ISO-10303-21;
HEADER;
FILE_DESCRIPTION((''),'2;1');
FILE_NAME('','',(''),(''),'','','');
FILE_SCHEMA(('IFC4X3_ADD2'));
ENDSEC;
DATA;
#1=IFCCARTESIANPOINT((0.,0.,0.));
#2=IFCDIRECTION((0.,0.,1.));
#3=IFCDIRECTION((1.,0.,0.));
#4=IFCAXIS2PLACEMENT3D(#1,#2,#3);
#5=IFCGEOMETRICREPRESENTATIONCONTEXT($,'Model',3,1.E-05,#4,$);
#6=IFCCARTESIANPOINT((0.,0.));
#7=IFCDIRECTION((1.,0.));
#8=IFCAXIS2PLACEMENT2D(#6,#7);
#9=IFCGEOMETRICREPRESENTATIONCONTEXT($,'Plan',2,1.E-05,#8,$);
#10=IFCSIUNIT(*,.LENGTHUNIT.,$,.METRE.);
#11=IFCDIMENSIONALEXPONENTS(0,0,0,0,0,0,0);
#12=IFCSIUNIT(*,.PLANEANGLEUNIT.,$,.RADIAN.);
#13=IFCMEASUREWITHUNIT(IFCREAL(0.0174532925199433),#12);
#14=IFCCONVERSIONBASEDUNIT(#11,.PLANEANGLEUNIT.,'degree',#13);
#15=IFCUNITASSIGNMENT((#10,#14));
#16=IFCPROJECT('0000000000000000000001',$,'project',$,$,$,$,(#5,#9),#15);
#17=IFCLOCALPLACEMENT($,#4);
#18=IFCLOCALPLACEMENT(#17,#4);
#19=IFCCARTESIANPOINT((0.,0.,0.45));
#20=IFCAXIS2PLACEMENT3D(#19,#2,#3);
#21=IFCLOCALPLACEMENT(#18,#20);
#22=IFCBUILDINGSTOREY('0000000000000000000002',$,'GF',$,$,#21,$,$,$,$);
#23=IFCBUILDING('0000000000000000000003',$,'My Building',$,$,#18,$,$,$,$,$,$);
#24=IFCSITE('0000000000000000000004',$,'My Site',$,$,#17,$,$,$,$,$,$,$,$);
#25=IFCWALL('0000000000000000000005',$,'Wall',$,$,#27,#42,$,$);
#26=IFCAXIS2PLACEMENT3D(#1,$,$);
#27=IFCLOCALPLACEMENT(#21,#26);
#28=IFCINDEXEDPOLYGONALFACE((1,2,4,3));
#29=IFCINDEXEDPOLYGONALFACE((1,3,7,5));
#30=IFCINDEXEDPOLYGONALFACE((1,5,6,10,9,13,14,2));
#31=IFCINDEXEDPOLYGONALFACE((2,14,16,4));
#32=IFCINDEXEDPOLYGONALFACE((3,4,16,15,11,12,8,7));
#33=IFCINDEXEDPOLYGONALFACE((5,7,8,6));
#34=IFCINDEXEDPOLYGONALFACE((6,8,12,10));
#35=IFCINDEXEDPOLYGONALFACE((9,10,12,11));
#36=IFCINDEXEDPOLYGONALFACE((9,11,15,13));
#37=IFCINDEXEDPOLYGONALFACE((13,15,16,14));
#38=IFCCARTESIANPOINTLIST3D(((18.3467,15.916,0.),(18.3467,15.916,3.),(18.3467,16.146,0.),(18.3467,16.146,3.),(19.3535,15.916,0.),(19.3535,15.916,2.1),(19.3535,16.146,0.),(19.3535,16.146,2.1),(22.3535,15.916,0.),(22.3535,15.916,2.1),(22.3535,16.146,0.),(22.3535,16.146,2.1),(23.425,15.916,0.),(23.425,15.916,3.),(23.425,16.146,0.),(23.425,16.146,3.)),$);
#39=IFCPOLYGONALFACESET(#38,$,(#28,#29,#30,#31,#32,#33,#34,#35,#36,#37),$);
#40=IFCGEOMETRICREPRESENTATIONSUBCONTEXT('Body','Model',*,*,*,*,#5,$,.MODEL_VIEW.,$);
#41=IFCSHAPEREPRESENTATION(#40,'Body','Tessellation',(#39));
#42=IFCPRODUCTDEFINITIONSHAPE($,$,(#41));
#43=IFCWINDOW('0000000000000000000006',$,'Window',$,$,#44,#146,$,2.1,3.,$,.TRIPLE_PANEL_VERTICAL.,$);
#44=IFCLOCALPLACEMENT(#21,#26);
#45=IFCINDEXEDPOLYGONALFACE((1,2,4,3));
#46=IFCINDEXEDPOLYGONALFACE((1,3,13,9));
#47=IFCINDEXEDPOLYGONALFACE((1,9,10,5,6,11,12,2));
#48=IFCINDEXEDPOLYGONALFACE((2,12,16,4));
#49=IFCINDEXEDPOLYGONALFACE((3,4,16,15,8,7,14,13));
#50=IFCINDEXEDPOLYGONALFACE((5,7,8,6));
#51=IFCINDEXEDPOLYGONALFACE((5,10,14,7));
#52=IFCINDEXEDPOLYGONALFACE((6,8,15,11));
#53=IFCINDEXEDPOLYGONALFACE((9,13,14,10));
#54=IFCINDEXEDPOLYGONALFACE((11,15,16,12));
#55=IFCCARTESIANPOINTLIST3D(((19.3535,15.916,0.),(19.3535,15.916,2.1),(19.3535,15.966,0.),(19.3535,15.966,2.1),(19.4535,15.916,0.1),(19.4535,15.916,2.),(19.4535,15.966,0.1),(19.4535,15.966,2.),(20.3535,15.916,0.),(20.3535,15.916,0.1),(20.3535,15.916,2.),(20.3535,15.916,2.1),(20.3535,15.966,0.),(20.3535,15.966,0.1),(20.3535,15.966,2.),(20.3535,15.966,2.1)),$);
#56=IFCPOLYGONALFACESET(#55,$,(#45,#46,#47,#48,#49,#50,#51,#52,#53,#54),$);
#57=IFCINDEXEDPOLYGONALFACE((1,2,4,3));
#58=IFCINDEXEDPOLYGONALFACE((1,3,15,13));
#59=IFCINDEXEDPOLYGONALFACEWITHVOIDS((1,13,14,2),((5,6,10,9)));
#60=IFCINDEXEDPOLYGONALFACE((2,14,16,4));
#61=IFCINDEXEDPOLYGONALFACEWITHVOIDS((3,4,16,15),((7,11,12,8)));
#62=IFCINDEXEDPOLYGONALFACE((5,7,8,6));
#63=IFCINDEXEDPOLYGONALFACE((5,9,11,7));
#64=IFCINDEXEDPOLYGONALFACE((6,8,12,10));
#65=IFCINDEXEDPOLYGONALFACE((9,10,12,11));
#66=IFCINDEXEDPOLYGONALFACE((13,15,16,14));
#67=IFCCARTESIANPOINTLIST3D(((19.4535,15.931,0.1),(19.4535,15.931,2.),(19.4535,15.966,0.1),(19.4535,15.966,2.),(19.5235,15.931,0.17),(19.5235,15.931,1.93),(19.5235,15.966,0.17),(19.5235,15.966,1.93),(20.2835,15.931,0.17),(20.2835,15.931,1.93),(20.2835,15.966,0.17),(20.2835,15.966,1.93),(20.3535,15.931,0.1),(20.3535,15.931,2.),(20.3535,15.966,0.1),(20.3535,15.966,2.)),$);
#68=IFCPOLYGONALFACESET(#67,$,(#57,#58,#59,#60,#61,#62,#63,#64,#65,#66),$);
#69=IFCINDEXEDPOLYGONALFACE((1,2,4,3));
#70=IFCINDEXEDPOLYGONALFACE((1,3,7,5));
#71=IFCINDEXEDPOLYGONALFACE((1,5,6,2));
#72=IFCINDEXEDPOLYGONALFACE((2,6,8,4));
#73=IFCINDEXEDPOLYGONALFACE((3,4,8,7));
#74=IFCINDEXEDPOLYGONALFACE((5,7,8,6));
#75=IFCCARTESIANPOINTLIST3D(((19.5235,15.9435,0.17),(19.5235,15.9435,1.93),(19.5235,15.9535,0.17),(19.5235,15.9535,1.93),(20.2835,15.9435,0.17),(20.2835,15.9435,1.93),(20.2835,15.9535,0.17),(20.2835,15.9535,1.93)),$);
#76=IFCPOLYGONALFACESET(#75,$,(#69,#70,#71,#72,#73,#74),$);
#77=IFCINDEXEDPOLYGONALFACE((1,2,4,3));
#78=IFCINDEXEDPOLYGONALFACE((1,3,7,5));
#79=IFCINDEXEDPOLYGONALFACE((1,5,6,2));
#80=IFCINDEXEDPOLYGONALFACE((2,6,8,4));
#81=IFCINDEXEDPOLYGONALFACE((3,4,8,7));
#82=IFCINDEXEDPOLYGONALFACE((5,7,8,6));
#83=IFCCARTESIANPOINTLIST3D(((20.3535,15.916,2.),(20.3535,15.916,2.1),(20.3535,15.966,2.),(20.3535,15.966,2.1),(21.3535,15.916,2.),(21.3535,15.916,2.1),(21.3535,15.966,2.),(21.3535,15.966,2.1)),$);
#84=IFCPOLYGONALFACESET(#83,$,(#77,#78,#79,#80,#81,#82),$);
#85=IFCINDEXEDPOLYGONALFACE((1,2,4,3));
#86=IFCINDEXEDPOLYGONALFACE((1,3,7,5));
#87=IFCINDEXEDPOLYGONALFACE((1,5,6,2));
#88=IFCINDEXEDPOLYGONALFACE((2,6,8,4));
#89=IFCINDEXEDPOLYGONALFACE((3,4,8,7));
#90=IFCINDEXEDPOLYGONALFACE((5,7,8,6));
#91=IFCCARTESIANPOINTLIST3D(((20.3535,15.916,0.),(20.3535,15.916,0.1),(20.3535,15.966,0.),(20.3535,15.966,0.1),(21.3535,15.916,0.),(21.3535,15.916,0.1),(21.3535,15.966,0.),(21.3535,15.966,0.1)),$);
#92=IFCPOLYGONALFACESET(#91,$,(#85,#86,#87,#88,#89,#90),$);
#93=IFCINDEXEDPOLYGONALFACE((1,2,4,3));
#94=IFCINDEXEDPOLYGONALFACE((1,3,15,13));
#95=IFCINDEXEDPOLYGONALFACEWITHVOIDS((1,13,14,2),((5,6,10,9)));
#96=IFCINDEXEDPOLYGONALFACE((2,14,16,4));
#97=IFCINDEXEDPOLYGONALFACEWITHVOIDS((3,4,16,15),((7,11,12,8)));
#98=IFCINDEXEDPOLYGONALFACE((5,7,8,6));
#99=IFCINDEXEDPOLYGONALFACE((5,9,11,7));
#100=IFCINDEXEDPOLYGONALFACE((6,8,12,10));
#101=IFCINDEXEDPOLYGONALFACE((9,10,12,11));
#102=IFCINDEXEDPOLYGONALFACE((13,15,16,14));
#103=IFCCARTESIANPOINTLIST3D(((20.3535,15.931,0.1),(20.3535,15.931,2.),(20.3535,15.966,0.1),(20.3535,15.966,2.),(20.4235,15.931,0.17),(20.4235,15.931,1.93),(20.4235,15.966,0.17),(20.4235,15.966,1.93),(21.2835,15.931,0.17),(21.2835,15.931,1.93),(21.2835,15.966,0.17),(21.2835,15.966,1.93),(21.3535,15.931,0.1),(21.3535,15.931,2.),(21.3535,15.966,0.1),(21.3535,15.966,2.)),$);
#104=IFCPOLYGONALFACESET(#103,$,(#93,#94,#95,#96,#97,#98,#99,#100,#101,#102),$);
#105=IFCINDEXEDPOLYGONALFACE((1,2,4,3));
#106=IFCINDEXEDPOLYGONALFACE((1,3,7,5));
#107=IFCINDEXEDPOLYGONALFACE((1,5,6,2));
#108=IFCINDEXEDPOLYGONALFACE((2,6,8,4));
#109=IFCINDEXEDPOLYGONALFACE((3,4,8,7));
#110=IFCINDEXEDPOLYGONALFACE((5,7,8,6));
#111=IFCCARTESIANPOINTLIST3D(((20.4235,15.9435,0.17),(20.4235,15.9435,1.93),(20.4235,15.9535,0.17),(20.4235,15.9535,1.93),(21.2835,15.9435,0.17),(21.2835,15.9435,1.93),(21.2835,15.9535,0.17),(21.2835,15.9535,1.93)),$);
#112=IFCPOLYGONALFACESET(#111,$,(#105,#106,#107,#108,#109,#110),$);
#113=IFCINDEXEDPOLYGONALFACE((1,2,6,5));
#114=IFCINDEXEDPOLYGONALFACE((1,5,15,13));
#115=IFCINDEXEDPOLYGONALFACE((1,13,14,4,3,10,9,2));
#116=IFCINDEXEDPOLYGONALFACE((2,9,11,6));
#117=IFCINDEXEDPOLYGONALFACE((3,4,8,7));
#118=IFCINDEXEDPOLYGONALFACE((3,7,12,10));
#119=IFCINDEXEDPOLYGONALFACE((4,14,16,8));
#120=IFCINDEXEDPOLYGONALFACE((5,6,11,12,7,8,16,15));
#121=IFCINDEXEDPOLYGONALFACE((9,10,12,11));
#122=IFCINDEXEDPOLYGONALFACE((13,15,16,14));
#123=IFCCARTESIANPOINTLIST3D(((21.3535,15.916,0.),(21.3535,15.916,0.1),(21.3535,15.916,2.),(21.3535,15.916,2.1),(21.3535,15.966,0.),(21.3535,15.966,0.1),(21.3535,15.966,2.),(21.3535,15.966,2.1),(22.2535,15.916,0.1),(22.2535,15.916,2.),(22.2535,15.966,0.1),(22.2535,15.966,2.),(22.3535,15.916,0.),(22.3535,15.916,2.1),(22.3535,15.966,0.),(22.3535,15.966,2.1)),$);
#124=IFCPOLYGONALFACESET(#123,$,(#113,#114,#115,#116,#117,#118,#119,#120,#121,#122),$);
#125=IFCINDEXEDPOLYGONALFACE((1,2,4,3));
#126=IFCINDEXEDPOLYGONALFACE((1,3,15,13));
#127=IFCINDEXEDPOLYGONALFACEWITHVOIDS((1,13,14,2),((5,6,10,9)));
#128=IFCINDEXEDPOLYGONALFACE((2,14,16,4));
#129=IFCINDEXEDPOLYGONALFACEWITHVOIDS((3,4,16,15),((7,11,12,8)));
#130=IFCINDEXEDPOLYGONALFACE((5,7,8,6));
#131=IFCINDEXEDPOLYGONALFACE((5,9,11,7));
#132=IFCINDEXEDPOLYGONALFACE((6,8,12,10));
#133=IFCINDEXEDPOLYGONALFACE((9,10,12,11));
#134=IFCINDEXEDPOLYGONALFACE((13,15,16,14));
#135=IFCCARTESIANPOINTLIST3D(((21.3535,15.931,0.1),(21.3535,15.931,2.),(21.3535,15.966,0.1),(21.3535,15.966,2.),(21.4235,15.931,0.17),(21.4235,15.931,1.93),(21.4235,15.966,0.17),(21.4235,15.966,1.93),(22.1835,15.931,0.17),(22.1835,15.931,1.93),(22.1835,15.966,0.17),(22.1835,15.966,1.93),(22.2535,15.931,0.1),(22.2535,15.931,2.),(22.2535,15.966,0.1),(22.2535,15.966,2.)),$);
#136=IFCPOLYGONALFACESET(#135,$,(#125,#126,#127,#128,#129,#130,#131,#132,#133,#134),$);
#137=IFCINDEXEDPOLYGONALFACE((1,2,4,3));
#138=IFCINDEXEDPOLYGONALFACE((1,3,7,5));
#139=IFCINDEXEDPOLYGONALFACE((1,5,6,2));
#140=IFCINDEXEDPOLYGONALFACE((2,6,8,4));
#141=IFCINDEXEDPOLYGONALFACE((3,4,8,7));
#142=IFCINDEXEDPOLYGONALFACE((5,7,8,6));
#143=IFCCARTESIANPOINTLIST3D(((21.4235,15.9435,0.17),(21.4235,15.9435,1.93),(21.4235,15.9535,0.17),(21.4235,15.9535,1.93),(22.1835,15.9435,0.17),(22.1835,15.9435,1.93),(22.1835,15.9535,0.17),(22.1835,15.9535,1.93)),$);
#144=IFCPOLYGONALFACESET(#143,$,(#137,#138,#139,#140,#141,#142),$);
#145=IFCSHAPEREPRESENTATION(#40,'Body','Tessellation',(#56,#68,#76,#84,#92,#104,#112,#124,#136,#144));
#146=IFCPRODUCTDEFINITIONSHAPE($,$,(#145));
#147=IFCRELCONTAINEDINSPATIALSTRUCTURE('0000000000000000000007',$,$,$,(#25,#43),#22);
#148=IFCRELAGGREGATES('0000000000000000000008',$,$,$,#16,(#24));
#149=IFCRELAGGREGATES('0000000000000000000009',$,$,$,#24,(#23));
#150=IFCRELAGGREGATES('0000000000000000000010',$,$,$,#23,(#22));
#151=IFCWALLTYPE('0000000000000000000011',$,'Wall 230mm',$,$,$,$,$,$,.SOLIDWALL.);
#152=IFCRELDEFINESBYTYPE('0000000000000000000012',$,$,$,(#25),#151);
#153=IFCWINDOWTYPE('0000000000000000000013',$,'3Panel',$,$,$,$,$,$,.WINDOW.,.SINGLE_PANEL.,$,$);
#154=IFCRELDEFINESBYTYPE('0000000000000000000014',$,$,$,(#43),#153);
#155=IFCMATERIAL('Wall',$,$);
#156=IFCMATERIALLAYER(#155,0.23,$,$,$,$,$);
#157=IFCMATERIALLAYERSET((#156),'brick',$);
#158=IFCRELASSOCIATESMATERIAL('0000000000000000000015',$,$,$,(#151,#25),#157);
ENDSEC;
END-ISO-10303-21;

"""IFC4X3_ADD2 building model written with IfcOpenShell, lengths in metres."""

from ifc_helpers import new_model, entity, si_unit, converted_unit, frame, origin_with_axes, origin_2d_with_axis, place, context, subcontext, project, spatial, line, indexed_curve, outline, extrude, shape, source, transform, mapped, material, layer, layer_set, layer_usage, type_object, type_shapes, element, fill, save


model = new_model("IFC4X3_ADD2")

# Units and contexts
model_context = context("Model", 3, precision=1e-05, world=origin_with_axes())
plan_context = context("Plan", 2, precision=1e-05, world=origin_2d_with_axis())
body_context_1 = subcontext(model_context, "Body", "Model", "MODEL_VIEW")
body_context_2 = subcontext(plan_context, "Body", "Plan", "PLAN_VIEW")
ifc_project = project(units=[si_unit("LENGTHUNIT", "METRE"), converted_unit("PLANEANGLEUNIT", "degree", entity("IfcReal", 0.0174532925199433), si_unit("PLANEANGLEUNIT", "RADIAN"), dimensions=[0, 0, 0, 0, 0, 0, 0])], contexts=[model_context, plan_context])

# Site, building, storey
site_placement = place(None, origin_with_axes())
site = spatial("IfcSite", under=ifc_project, at=site_placement, Name="My Site")
building_placement = place(site_placement, origin_with_axes())
building = spatial("IfcBuilding", under=site, at=building_placement, Name="My Building")
storey_placement = place(building_placement, frame((0.0, 0.0, 0.45), z_axis=(0.0, 0.0, 1.0), x_axis=(1.0, 0.0, 0.0)))
storey = spatial("IfcBuildingStorey", under=building, at=storey_placement, Name="GF")

# Shared definitions
ifc_material_1 = material(Name="Wall")
ifc_layer = layer(ifc_material_1, 0.23)
ifc_layer_set = layer_set([ifc_layer], Name="brick")
wall_type = type_object("IfcWallType", Name="Wall 230mm", PredefinedType="SOLIDWALL", material=ifc_layer_set)

# Wall, opening, window
ifc_layer_usage_1 = layer_usage(ifc_layer_set, "AXIS2", "POSITIVE", 0.0)
wall_1_placement = place(storey_placement, frame((18.3467, 15.916, 0.0), z_axis=(0.0, 0.0, 1.0), x_axis=(1.0, 0.0, 0.0)))
wall_1 = element("IfcWall", 1, at=wall_1_placement, inside=storey, type_object=wall_type, material=ifc_layer_usage_1, Name="Wall", context=body_context_1, shape_type="SweptSolid", body=[
    extrude(outline(indexed_curve([(0.0, 0.0), (0.0, 0.23), (5.0783, 0.23), (5.0783, 0.0), (0.0, 0.0)], self_intersect=False)), origin_with_axes(), (0.0, 0.0, 1.0), 3.0),
])
shared_shape_1 = source(origin_with_axes(), body_context_1, "Body", "SweptSolid", [
    extrude(outline(indexed_curve([(0.0, 0.0), (3.0, 0.0), (3.0, 2.1), (0.0, 2.1)], segments=[line(1, 2, 3, 4, 1)])), frame((0.0, -0.6, 0.0), z_axis=(0.0, -1.0, 0.0), x_axis=(1.0, 0.0, 0.0)), (0.0, 0.0, -1.0), 1.2),
])
opening_1_placement = place(wall_1_placement, frame((1.0068, 0.0333, 0.0), z_axis=(0.0, 0.0, 1.0), x_axis=(1.0, 0.0, 0.0)))
opening_1 = element("IfcOpeningElement", 2, at=opening_1_placement, cuts=wall_1, PredefinedType="OPENING", context=body_context_1, shape_type="MappedRepresentation", body=[
    mapped(shared_shape_1, transform((0.0, 0.0, 0.0), x_axis=(1.0, 0.0, 0.0), y_axis=(0.0, 1.0, 0.0), z_axis=(0.0, 0.0, 1.0), scale=1.0)),
])
window_type = type_object("IfcWindowType", Name="3Panel", PartitioningType="SINGLE_PANEL", PredefinedType="WINDOW")
shared_shape_2 = source(origin_with_axes(), body_context_1, "Body", "SweptSolid", [
    extrude(outline(indexed_curve([(1.0, 0.0), (0.0, 0.0), (0.0, 2.1), (1.0, 2.1), (1.0, 2.0), (0.1, 2.0), (0.1, 0.1), (1.0, 0.1)], segments=[line(1, 2, 3, 4, 5, 6, 7, 8, 1)])), frame((0.0, 0.0, 0.0), z_axis=(0.0, -1.0, 0.0), x_axis=(1.0, 0.0, 0.0)), (0.0, 0.0, -1.0), 0.05),
    extrude(outline(indexed_curve([(0.0, 0.0), (0.9, 0.0), (0.9, 1.9), (0.0, 1.9)], segments=[line(1, 2, 3, 4, 1)]), holes=[indexed_curve([(0.07, 0.07), (0.83, 0.07), (0.83, 1.83), (0.07, 1.83)], segments=[line(1, 2, 3, 4, 1)])]), frame((0.1, 0.015, 0.1), z_axis=(0.0, -1.0, 0.0), x_axis=(1.0, 0.0, 0.0)), (0.0, 0.0, -1.0), 0.035),
    extrude(outline(indexed_curve([(0.07, 0.07), (0.83, 0.07), (0.83, 1.83), (0.07, 1.83)], segments=[line(1, 2, 3, 4, 1)])), frame((0.1, 0.0275, 0.1), z_axis=(0.0, -1.0, 0.0), x_axis=(1.0, 0.0, 0.0)), (0.0, 0.0, -1.0), 0.01),
    extrude(outline(indexed_curve([(0.0, 2.1), (1.0, 2.1), (1.0, 2.0), (0.0, 2.0)], segments=[line(1, 2, 3, 4, 1)])), frame((1.0, 0.0, 0.0), z_axis=(0.0, -1.0, 0.0), x_axis=(1.0, 0.0, 0.0)), (0.0, 0.0, -1.0), 0.05),
    extrude(outline(indexed_curve([(1.0, 0.0), (0.0, 0.0), (0.0, 0.1), (1.0, 0.1)], segments=[line(1, 2, 3, 4, 1)])), frame((1.0, 0.0, 0.0), z_axis=(0.0, -1.0, 0.0), x_axis=(1.0, 0.0, 0.0)), (0.0, 0.0, -1.0), 0.05),
    extrude(outline(indexed_curve([(0.0, 0.0), (1.0, 0.0), (1.0, 1.9), (0.0, 1.9)], segments=[line(1, 2, 3, 4, 1)]), holes=[indexed_curve([(0.07, 0.07), (0.93, 0.07), (0.93, 1.83), (0.07, 1.83)], segments=[line(1, 2, 3, 4, 1)])]), frame((1.0, 0.015, 0.1), z_axis=(0.0, -1.0, 0.0), x_axis=(1.0, 0.0, 0.0)), (0.0, 0.0, -1.0), 0.035),
    extrude(outline(indexed_curve([(0.07, 0.07), (0.93, 0.07), (0.93, 1.83), (0.07, 1.83)], segments=[line(1, 2, 3, 4, 1)])), frame((1.0, 0.0275, 0.1), z_axis=(0.0, -1.0, 0.0), x_axis=(1.0, 0.0, 0.0)), (0.0, 0.0, -1.0), 0.01),
    extrude(outline(indexed_curve([(0.0, 2.1), (1.0, 2.1), (1.0, 0.0), (0.0, 0.0), (0.0, 0.1), (0.9, 0.1), (0.9, 2.0), (0.0, 2.0)], segments=[line(1, 2, 3, 4, 5, 6, 7, 8, 1)])), frame((2.0, 0.0, 0.0), z_axis=(0.0, -1.0, 0.0), x_axis=(1.0, 0.0, 0.0)), (0.0, 0.0, -1.0), 0.05),
    extrude(outline(indexed_curve([(0.0, 0.0), (0.9, 0.0), (0.9, 1.9), (0.0, 1.9)], segments=[line(1, 2, 3, 4, 1)]), holes=[indexed_curve([(0.07, 0.07), (0.83, 0.07), (0.83, 1.83), (0.07, 1.83)], segments=[line(1, 2, 3, 4, 1)])]), frame((2.0, 0.015, 0.1), z_axis=(0.0, -1.0, 0.0), x_axis=(1.0, 0.0, 0.0)), (0.0, 0.0, -1.0), 0.035),
    extrude(outline(indexed_curve([(0.07, 0.07), (0.83, 0.07), (0.83, 1.83), (0.07, 1.83)], segments=[line(1, 2, 3, 4, 1)])), frame((2.0, 0.0275, 0.1), z_axis=(0.0, -1.0, 0.0), x_axis=(1.0, 0.0, 0.0)), (0.0, 0.0, -1.0), 0.01),
])
shared_shape_3 = source(origin_with_axes(), body_context_2, "Body", "Curve2D", [
    entity("IfcIndexedPolyCurve", entity("IfcCartesianPointList2D", [[0.1, 0.0], [1.0, 0.0]])),
    entity("IfcIndexedPolyCurve", entity("IfcCartesianPointList2D", [[0.0, 0.05], [0.1, 0.05], [0.1, 0.0], [0.0, 0.0]]), [entity("IfcLineIndex", [1, 2, 3, 4, 1])]),
    entity("IfcIndexedPolyCurve", entity("IfcCartesianPointList2D", [[1.0, 0.05], [1.0, 0.05], [1.0, 0.0], [1.0, 0.0]])),
    entity("IfcIndexedPolyCurve", entity("IfcCartesianPointList2D", [[0.1, 0.015], [0.17, 0.015], [0.17, 0.05], [0.1, 0.05]]), [entity("IfcLineIndex", [1, 2, 3, 4, 1])]),
    entity("IfcIndexedPolyCurve", entity("IfcCartesianPointList2D", [[1.0, 0.015], [0.93, 0.015], [0.93, 0.05], [1.0, 0.05]]), [entity("IfcLineIndex", [1, 2, 3, 4, 1])]),
    entity("IfcIndexedPolyCurve", entity("IfcCartesianPointList2D", [[0.17, 0.015], [0.93, 0.015]])),
    entity("IfcIndexedPolyCurve", entity("IfcCartesianPointList2D", [[0.17, 0.05], [0.93, 0.05]])),
    entity("IfcIndexedPolyCurve", entity("IfcCartesianPointList2D", [[0.17, 0.0325], [0.93, 0.0325]])),
    entity("IfcIndexedPolyCurve", entity("IfcCartesianPointList2D", [[1.0, 0.0], [2.0, 0.0]])),
    entity("IfcIndexedPolyCurve", entity("IfcCartesianPointList2D", [[1.0, 0.05], [1.0, 0.05], [1.0, 0.0], [1.0, 0.0]])),
    entity("IfcIndexedPolyCurve", entity("IfcCartesianPointList2D", [[2.0, 0.05], [2.0, 0.05], [2.0, 0.0], [2.0, 0.0]])),
    entity("IfcIndexedPolyCurve", entity("IfcCartesianPointList2D", [[1.0, 0.015], [1.07, 0.015], [1.07, 0.05], [1.0, 0.05]]), [entity("IfcLineIndex", [1, 2, 3, 4, 1])]),
    entity("IfcIndexedPolyCurve", entity("IfcCartesianPointList2D", [[2.0, 0.015], [1.93, 0.015], [1.93, 0.05], [2.0, 0.05]]), [entity("IfcLineIndex", [1, 2, 3, 4, 1])]),
    entity("IfcIndexedPolyCurve", entity("IfcCartesianPointList2D", [[1.07, 0.015], [1.93, 0.015]])),
    entity("IfcIndexedPolyCurve", entity("IfcCartesianPointList2D", [[1.07, 0.05], [1.93, 0.05]])),
    entity("IfcIndexedPolyCurve", entity("IfcCartesianPointList2D", [[1.07, 0.0325], [1.93, 0.0325]])),
    entity("IfcIndexedPolyCurve", entity("IfcCartesianPointList2D", [[2.0, 0.0], [2.9, 0.0]])),
    entity("IfcIndexedPolyCurve", entity("IfcCartesianPointList2D", [[2.0, 0.05], [2.0, 0.05], [2.0, 0.0], [2.0, 0.0]])),
    entity("IfcIndexedPolyCurve", entity("IfcCartesianPointList2D", [[3.0, 0.05], [2.9, 0.05], [2.9, 0.0], [3.0, 0.0]]), [entity("IfcLineIndex", [1, 2, 3, 4, 1])]),
    entity("IfcIndexedPolyCurve", entity("IfcCartesianPointList2D", [[2.0, 0.015], [2.07, 0.015], [2.07, 0.05], [2.0, 0.05]]), [entity("IfcLineIndex", [1, 2, 3, 4, 1])]),
    entity("IfcIndexedPolyCurve", entity("IfcCartesianPointList2D", [[2.9, 0.015], [2.83, 0.015], [2.83, 0.05], [2.9, 0.05]]), [entity("IfcLineIndex", [1, 2, 3, 4, 1])]),
    entity("IfcIndexedPolyCurve", entity("IfcCartesianPointList2D", [[2.07, 0.015], [2.83, 0.015]])),
    entity("IfcIndexedPolyCurve", entity("IfcCartesianPointList2D", [[2.07, 0.05], [2.83, 0.05]])),
    entity("IfcIndexedPolyCurve", entity("IfcCartesianPointList2D", [[2.07, 0.0325], [2.83, 0.0325]])),
])
type_shapes(window_type, [shared_shape_2, shared_shape_3])
placement_1 = place(storey_placement, frame((15.0467, 15.916, 0.0), z_axis=(0.0, 0.0, 1.0), x_axis=(1.0, 0.0, 0.0)))
placement_2 = place(placement_1, frame((4.3068, 0.0, 0.0), z_axis=(0.0, 0.0, 1.0), x_axis=(1.0, 0.0, 0.0)))
window_placement = place(placement_2, origin_with_axes())
window = element("IfcWindow", 3, at=window_placement, inside=storey, type_object=window_type, Name="Window", OverallHeight=2.1, OverallWidth=3.0, PartitioningType="TRIPLE_PANEL_VERTICAL", shapes=[
    shape(body_context_1, "Body", "MappedRepresentation", [mapped(shared_shape_2, transform((0.0, 0.0, 0.0), x_axis=(1.0, 0.0, 0.0), y_axis=(0.0, 1.0, 0.0), z_axis=(0.0, 0.0, 1.0), scale=1.0))]),
    shape(body_context_2, "Body", "MappedRepresentation", [mapped(shared_shape_3, transform((0.0, 0.0, 0.0), x_axis=(1.0, 0.0, 0.0), y_axis=(0.0, 1.0, 0.0), z_axis=(0.0, 0.0, 1.0), scale=1.0))]),
])
fill(opening_1, window)

save(model, "model.ifc")
